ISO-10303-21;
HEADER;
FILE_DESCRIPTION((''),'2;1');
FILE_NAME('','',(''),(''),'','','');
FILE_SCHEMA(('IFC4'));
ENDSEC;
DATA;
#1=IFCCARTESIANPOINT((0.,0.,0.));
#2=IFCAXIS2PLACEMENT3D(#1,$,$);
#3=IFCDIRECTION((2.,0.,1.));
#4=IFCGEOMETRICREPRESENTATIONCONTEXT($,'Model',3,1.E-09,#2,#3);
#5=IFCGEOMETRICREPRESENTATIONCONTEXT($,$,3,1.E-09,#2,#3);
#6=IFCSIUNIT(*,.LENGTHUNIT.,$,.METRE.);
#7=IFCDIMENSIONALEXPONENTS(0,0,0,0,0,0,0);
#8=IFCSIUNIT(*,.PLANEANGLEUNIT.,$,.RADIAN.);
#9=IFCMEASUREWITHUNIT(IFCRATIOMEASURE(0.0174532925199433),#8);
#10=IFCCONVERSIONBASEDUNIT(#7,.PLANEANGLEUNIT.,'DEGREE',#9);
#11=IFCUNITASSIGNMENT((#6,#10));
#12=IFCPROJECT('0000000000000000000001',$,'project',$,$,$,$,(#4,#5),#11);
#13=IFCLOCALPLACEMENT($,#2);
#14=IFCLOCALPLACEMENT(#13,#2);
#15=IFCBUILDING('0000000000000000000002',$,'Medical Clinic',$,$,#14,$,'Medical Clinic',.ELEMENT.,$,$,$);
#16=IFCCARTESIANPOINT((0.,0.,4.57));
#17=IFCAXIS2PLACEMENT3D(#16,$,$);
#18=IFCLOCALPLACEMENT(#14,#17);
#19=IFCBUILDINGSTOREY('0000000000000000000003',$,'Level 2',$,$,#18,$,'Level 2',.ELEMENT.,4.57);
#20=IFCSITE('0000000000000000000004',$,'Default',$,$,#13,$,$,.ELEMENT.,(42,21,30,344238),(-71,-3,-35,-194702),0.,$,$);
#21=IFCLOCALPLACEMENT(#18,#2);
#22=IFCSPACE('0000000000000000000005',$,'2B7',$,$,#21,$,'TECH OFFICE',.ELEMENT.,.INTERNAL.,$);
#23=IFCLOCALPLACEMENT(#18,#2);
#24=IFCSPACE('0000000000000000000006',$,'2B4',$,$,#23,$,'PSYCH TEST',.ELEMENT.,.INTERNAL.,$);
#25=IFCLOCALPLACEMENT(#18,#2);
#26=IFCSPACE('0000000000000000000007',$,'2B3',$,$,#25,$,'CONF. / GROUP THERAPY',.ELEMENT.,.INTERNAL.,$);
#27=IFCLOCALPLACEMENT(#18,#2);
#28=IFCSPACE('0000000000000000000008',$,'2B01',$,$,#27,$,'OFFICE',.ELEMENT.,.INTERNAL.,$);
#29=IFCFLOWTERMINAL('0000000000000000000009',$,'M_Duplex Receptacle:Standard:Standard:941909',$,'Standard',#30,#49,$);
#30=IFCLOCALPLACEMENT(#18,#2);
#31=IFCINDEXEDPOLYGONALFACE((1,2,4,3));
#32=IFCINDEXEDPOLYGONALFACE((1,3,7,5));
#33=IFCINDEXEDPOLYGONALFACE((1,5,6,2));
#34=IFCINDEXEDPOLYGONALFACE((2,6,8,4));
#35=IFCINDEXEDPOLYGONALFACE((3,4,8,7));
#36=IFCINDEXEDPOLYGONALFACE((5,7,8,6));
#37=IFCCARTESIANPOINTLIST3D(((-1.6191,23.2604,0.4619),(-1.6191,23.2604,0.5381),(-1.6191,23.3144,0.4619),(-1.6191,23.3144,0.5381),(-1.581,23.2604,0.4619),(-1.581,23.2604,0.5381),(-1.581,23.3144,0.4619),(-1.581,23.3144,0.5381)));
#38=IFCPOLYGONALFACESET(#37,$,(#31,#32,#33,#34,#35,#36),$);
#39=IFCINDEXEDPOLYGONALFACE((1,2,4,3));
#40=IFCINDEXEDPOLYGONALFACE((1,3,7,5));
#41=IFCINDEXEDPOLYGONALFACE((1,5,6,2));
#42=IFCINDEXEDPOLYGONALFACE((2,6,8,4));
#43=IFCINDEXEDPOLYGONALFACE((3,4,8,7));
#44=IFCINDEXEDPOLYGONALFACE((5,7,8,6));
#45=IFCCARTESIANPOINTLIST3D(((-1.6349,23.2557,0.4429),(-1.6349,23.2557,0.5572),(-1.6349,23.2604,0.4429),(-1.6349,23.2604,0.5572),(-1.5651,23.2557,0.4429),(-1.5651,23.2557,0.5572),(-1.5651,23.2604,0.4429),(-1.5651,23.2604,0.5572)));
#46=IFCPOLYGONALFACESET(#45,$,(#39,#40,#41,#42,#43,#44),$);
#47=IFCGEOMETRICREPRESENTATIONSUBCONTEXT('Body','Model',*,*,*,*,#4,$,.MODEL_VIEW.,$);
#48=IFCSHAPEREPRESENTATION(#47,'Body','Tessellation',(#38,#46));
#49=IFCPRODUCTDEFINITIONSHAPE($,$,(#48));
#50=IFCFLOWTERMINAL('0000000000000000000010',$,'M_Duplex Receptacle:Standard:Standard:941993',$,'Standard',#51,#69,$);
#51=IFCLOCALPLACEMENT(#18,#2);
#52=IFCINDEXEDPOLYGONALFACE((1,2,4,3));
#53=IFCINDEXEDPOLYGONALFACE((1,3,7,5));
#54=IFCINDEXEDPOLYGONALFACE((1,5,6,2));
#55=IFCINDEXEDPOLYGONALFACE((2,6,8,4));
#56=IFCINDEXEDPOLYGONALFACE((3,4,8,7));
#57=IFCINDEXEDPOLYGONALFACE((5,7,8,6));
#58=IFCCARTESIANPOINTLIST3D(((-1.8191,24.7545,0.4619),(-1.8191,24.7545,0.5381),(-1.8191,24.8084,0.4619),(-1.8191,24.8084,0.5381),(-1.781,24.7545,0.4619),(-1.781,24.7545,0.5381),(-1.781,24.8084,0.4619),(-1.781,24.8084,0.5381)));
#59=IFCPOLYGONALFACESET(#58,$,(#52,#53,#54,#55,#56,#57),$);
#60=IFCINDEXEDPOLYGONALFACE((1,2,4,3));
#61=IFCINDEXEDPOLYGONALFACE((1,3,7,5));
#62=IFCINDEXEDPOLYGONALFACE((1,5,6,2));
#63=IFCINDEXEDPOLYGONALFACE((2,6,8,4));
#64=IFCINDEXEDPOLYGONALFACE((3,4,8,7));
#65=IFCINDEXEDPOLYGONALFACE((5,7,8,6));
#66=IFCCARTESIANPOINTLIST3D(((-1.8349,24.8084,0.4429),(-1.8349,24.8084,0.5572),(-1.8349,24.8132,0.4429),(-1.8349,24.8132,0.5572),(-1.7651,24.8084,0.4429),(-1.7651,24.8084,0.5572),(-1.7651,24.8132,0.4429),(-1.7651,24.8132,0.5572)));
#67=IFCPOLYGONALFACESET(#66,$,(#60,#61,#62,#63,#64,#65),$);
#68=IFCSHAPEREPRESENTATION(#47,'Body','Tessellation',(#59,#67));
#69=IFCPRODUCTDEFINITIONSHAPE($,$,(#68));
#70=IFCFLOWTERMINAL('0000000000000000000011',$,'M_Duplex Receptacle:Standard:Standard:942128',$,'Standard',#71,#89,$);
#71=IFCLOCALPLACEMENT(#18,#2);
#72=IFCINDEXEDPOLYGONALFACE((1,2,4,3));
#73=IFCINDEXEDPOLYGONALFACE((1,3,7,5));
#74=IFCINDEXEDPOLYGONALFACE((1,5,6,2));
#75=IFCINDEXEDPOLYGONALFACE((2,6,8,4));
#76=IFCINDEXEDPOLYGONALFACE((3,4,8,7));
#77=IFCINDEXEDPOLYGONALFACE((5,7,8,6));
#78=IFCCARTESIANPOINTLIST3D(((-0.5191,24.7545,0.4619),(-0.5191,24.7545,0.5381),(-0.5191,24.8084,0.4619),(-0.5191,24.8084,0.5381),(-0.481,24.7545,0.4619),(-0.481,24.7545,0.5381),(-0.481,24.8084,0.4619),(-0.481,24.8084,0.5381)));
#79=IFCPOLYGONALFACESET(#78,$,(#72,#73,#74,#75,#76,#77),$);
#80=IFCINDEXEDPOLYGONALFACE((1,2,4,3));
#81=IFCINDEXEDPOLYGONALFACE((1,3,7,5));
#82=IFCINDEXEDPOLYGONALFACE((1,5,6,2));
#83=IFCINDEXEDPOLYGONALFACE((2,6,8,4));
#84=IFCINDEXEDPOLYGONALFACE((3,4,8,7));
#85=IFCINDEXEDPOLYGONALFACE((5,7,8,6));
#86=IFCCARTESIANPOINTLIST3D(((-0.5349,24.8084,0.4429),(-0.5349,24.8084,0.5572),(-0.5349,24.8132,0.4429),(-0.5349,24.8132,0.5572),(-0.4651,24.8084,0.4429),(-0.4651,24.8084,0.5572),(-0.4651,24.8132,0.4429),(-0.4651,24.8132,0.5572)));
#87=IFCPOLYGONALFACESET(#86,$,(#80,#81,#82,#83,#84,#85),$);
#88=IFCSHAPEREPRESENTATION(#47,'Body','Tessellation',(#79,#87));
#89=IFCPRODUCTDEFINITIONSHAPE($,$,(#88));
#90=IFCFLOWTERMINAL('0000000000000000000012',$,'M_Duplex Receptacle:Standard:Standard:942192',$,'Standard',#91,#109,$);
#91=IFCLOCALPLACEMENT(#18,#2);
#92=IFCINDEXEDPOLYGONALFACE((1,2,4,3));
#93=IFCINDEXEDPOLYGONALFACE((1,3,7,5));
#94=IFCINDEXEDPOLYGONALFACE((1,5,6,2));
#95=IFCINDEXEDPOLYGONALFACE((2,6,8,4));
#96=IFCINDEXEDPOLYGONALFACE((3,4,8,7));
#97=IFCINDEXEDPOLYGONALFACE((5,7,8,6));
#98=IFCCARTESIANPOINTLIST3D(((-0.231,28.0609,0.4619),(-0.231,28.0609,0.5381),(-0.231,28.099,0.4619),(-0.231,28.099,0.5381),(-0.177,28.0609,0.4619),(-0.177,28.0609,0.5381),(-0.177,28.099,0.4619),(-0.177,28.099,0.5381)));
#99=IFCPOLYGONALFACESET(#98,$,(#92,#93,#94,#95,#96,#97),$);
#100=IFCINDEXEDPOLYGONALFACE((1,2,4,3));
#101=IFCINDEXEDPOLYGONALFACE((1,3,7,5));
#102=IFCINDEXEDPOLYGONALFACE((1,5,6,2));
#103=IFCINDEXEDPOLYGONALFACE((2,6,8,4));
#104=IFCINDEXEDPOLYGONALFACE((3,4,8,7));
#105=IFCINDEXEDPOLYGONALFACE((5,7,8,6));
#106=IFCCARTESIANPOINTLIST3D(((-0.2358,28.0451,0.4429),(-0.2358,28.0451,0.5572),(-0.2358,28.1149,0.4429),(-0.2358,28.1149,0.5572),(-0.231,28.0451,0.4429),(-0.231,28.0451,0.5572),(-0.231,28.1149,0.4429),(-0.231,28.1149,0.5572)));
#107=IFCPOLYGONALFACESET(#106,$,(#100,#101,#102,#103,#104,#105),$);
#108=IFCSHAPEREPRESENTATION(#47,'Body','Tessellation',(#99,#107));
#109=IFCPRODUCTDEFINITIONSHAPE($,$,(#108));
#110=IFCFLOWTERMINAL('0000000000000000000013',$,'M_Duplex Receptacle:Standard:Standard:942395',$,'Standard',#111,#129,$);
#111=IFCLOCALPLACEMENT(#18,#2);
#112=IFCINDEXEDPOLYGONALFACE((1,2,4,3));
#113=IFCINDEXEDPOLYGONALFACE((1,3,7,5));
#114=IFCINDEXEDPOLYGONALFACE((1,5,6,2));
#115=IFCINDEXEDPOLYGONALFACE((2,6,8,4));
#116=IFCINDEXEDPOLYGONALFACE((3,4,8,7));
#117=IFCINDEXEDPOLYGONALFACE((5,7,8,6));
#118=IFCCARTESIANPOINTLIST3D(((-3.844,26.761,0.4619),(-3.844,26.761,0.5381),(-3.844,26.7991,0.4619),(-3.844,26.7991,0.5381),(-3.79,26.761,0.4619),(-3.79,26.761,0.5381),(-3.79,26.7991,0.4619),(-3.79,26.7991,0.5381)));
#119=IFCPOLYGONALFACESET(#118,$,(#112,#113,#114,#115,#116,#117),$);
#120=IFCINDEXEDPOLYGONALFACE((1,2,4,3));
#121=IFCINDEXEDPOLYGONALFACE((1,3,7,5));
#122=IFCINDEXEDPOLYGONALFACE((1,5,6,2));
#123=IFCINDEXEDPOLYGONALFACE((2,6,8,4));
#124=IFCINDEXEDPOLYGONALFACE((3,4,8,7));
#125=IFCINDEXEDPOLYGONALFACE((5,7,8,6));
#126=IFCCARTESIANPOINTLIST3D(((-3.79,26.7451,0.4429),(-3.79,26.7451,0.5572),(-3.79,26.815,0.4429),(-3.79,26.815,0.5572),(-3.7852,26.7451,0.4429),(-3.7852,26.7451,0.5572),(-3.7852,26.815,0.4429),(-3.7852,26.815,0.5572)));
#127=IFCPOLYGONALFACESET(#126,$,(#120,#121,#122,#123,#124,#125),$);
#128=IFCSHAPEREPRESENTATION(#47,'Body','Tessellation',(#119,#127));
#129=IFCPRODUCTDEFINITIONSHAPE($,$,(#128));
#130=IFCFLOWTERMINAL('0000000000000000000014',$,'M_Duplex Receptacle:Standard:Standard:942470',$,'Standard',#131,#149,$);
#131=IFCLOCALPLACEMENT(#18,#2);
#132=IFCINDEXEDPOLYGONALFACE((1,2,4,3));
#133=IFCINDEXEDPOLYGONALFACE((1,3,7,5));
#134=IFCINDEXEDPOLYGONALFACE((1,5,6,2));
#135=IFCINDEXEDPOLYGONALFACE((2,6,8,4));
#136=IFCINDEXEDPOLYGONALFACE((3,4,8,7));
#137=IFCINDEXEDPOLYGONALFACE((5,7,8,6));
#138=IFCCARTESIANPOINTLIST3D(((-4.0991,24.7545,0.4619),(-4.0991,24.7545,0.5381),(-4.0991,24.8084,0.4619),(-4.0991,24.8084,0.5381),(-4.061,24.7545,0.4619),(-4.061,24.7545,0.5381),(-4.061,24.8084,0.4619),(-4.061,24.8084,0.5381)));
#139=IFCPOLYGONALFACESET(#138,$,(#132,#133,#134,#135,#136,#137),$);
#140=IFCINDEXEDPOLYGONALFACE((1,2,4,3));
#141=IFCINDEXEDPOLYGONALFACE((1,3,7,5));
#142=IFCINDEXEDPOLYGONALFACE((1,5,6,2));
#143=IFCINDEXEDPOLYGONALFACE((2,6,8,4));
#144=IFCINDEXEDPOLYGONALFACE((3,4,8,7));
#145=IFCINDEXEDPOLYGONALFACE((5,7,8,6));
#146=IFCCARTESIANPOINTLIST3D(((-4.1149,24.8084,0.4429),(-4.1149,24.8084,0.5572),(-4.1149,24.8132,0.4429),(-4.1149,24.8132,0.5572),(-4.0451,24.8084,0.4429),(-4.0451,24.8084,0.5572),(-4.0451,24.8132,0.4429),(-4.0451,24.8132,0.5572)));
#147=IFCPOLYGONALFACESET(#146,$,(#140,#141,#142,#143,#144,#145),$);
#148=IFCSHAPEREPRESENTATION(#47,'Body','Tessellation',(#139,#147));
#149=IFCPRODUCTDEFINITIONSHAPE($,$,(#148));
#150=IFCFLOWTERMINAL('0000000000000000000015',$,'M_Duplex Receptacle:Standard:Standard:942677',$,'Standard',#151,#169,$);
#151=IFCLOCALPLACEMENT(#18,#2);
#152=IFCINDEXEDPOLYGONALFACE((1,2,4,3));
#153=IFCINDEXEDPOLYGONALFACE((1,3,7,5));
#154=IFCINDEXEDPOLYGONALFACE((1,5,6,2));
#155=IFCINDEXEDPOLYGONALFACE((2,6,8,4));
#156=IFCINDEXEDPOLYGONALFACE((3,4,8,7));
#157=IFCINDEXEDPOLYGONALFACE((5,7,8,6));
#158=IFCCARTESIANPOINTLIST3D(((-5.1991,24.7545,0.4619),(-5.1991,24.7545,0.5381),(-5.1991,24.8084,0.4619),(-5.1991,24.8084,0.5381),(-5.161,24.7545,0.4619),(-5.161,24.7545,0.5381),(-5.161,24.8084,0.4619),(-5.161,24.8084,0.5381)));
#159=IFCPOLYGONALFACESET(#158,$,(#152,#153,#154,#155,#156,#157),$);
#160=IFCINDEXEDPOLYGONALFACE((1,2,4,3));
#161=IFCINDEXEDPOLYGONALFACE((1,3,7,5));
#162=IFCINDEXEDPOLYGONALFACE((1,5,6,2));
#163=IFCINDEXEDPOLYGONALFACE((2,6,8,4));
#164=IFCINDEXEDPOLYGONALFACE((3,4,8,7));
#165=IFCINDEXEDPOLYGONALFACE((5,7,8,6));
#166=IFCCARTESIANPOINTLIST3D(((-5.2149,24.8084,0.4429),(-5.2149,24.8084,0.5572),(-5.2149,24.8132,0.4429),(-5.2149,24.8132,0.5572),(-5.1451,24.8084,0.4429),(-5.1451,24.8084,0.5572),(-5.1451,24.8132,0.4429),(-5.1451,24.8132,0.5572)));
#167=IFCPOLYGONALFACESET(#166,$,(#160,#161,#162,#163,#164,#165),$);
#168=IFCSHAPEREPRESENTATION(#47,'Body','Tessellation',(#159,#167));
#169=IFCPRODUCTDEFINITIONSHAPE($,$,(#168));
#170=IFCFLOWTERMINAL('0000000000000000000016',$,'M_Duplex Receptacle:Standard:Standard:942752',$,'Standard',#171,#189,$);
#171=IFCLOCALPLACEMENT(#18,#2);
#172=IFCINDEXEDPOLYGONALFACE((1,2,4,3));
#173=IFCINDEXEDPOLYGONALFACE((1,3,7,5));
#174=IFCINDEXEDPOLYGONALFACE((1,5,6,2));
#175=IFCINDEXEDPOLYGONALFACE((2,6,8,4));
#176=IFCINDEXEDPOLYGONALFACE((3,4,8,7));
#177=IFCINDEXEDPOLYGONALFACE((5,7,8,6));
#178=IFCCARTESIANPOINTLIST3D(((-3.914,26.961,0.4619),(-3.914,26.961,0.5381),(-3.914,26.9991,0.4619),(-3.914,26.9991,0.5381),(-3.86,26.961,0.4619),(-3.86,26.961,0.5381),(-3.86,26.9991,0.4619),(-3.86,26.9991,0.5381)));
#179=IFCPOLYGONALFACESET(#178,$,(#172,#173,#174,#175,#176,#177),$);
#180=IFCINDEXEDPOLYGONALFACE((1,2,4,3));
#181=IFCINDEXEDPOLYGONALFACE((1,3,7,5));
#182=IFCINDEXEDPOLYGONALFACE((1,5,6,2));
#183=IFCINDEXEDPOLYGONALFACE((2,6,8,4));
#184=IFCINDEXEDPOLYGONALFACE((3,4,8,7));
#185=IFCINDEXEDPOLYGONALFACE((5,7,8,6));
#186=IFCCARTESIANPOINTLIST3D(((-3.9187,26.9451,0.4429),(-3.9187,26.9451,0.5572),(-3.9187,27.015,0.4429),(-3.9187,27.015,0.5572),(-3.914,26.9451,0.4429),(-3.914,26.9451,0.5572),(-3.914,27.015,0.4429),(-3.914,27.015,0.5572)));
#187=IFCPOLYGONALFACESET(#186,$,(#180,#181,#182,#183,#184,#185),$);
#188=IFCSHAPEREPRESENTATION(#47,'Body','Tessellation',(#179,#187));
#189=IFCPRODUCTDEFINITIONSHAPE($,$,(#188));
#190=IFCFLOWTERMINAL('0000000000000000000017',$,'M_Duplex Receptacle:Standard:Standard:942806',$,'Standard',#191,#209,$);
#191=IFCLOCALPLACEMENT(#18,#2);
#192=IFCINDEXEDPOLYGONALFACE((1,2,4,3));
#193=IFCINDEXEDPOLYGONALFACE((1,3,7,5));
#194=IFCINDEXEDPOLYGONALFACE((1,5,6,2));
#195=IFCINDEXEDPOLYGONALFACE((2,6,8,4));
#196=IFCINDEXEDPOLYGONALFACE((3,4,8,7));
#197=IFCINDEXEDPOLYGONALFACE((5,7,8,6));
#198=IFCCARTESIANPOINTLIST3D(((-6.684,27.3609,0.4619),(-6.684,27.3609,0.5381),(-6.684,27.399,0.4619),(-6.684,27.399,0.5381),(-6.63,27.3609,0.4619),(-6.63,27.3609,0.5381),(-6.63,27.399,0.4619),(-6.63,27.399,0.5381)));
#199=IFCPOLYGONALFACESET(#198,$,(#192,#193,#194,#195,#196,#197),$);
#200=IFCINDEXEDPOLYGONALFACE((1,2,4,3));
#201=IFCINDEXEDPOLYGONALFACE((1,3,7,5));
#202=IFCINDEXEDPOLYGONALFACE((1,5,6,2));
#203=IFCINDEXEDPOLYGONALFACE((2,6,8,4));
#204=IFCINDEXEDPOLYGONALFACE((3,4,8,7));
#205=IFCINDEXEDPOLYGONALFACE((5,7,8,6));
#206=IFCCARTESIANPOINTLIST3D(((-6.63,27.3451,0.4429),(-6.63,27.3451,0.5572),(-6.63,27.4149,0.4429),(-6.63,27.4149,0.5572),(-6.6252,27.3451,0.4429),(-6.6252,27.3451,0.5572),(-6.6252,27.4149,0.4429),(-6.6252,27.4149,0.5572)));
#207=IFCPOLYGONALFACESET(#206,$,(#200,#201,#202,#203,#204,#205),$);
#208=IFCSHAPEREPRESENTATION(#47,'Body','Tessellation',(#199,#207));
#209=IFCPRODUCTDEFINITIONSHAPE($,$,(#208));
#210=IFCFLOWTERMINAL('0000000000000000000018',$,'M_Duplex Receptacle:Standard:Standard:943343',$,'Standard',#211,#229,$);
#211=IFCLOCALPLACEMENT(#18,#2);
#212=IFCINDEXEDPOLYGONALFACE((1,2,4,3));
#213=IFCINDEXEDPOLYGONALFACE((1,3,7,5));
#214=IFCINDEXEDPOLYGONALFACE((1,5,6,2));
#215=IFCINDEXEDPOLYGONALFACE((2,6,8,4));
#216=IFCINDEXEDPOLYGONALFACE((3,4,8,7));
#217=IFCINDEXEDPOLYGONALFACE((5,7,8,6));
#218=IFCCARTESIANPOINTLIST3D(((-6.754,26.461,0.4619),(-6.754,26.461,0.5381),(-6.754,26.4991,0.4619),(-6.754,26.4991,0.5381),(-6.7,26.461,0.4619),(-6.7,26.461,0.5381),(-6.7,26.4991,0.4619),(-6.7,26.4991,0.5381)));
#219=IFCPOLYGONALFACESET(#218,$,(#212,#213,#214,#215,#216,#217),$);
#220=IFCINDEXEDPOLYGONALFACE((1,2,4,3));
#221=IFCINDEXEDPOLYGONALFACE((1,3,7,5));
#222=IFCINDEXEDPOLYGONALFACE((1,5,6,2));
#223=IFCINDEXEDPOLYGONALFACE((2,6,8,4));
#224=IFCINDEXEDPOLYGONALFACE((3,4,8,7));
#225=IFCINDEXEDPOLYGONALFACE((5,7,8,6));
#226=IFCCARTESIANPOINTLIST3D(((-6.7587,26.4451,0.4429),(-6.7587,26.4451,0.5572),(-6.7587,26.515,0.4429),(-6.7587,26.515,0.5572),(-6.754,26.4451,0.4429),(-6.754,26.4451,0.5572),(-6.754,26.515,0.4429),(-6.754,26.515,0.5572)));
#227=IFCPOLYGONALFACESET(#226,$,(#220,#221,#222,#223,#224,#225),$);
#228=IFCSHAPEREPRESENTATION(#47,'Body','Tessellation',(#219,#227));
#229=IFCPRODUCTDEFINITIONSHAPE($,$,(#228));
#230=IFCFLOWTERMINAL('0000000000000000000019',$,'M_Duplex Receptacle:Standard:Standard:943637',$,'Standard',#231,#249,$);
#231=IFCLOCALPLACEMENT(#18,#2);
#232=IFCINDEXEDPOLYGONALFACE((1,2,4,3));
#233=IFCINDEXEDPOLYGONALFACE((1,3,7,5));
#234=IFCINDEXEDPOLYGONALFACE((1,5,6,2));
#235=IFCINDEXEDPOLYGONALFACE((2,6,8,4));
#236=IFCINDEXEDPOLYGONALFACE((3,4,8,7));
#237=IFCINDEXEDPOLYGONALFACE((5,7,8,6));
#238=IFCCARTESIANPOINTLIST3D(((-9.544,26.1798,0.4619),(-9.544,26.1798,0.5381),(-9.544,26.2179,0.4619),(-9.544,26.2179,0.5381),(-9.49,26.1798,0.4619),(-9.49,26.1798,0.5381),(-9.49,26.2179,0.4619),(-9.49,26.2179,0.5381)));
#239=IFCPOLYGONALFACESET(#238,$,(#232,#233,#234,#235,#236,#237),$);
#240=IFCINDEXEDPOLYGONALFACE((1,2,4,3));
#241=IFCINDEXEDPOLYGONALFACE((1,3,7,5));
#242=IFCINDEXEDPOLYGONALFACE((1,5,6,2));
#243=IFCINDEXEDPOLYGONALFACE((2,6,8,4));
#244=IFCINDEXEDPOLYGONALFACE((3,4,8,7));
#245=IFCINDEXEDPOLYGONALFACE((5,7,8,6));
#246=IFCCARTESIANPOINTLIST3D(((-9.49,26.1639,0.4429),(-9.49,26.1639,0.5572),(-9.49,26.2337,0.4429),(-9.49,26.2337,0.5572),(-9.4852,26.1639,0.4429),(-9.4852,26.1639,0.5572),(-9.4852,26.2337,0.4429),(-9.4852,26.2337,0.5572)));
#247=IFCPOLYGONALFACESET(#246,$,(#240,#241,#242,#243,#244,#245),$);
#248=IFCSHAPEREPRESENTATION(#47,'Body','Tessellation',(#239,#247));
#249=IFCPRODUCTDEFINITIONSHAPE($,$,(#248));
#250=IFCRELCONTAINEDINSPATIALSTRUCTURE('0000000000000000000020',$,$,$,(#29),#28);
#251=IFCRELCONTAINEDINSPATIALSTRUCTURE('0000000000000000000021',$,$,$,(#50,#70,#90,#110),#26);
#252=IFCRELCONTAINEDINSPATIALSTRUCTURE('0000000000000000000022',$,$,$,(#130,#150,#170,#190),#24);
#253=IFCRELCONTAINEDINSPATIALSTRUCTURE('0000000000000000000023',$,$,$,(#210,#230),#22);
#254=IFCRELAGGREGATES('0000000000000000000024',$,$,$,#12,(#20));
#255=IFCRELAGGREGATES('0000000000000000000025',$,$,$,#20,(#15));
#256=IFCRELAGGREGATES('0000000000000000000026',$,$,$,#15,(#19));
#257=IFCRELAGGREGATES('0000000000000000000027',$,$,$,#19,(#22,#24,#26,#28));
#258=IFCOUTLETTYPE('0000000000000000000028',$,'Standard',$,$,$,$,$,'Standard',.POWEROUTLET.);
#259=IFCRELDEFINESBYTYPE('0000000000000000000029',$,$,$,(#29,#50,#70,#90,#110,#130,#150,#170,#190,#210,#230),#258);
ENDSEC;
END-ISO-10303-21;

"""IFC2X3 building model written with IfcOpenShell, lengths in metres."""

from ifc_helpers import new_model, entity, si_unit, converted_unit, direction, frame, frame_2d, origin, origin_2d_with_axis, place, context, subcontext, project, spatial, rectangle, extrude, source, transform, mapped, type_object, type_shapes, element, save


model = new_model("IFC2X3")

# Units and contexts
model_context = context("Model", 3, precision=1e-09, world=origin(), true_north=direction((2.0, 0.0, 1.0)))
context_of_model = context(None, 3, precision=1e-09, world=origin(), true_north=direction((2.0, 0.0, 1.0)))
body_context = subcontext(model_context, "Body", "Model", "MODEL_VIEW")
ifc_project = project(units=[si_unit("LENGTHUNIT", "METRE"), converted_unit("PLANEANGLEUNIT", "DEGREE", entity("IfcRatioMeasure", 0.0174532925199433), si_unit("PLANEANGLEUNIT", "RADIAN"), dimensions=[0, 0, 0, 0, 0, 0, 0])], contexts=[model_context, context_of_model])

# Site, building, storey
site_placement = place(None, origin())
site = spatial("IfcSite", under=ifc_project, at=site_placement, Name="Default", CompositionType="ELEMENT", RefLatitude=(42, 21, 30, 344238), RefLongitude=(-71, -3, -35, -194702), RefElevation=0.0)
building_placement = place(site_placement, origin())
building = spatial("IfcBuilding", under=site, at=building_placement, Name="Medical Clinic", LongName="Medical Clinic", CompositionType="ELEMENT")
storey_placement = place(building_placement, frame((0.0, 0.0, 4.57)))
storey = spatial("IfcBuildingStorey", under=building, at=storey_placement, Name="Level 2", LongName="Level 2", CompositionType="ELEMENT", Elevation=4.57)

# Shared definitions
space_1_placement = place(storey_placement, origin())
space_1 = spatial("IfcSpace", under=storey, at=space_1_placement, Name="2B7", LongName="TECH OFFICE", CompositionType="ELEMENT", InteriorOrExteriorSpace="INTERNAL")

# Shared definitions
space_2_placement = place(storey_placement, origin())
space_2 = spatial("IfcSpace", under=storey, at=space_2_placement, Name="2B4", LongName="PSYCH TEST", CompositionType="ELEMENT", InteriorOrExteriorSpace="INTERNAL")

# Shared definitions
space_3_placement = place(storey_placement, origin())
space_3 = spatial("IfcSpace", under=storey, at=space_3_placement, Name="2B3", LongName="CONF. / GROUP THERAPY", CompositionType="ELEMENT", InteriorOrExteriorSpace="INTERNAL")

# Shared definitions
space_4_placement = place(storey_placement, origin())
space_4 = spatial("IfcSpace", under=storey, at=space_4_placement, Name="2B01", LongName="OFFICE", CompositionType="ELEMENT", InteriorOrExteriorSpace="INTERNAL")

# Flow terminals
outlet_type = type_object("IfcOutletType", Name="Standard", ElementType="Standard", PredefinedType="POWEROUTLET")
shared_shape_1 = source(origin(), body_context, "Body", "SweptSolid", [
    extrude(rectangle(XDim=0.0381, YDim=0.0762, at=origin_2d_with_axis()), frame((0.0, 0.0, -0.054), z_axis=(0.0, 0.0, 1.0), x_axis=(-1.0, 0.0, 0.0)), (0.0, 0.0, 1.0), 0.054),
    extrude(rectangle(XDim=0.0698, YDim=0.1143, at=frame_2d((0.0, 0.0), x_axis=(1.0, 0.0))), frame((0.0, 0.0, 0.0), z_axis=(0.0, 0.0, 1.0), x_axis=(-1.0, 0.0, 0.0)), (0.0, 0.0, 1.0), 0.0048),
])
type_shapes(outlet_type, [shared_shape_1])
flow_terminal_1_placement = place(space_4_placement, frame((-1.6, 23.2604, 0.5), z_axis=(0.0, -1.0, 0.0), x_axis=(1.0, 0.0, 0.0)))
element("IfcFlowTerminal", 1, at=flow_terminal_1_placement, inside=space_4, type_object=outlet_type, Name="M_Duplex Receptacle:Standard:Standard:941909", ObjectType="Standard", context=body_context, shape_type="MappedRepresentation", body=[
    mapped(shared_shape_1, transform((0.0, 0.0, 0.0), scale=1.0)),
])
for number, where, z_axis, x_axis, name in (
    (2, (-1.8, 24.8084, 0.5), (0.0, 1.0, 0.0), (-1.0, 0.0, 0.0), "M_Duplex Receptacle:Standard:Standard:941993"),
    (3, (-0.5, 24.8084, 0.5), (0.0, 1.0, 0.0), (-1.0, 0.0, 0.0), "M_Duplex Receptacle:Standard:Standard:942128"),
    (4, (-0.231, 28.08, 0.5), (-1.0, 0.0, 0.0), (0.0, -1.0, 0.0), "M_Duplex Receptacle:Standard:Standard:942192"),
    (5, (-3.79, 26.7801, 0.5), (1.0, 0.0, 0.0), (0.0, 1.0, 0.0), "M_Duplex Receptacle:Standard:Standard:942395"),
):
    element("IfcFlowTerminal", number, at=place(space_3_placement, frame(where, z_axis=z_axis, x_axis=x_axis)), inside=space_3, type_object=outlet_type, Name=name, ObjectType="Standard", context=body_context, shape_type="MappedRepresentation", body=[
        mapped(shared_shape_1, transform((0.0, 0.0, 0.0), scale=1.0)),
    ])
for number, where, z_axis, x_axis, name in (
    (6, (-4.08, 24.8084, 0.5), (0.0, 1.0, 0.0), (-1.0, 0.0, 0.0), "M_Duplex Receptacle:Standard:Standard:942470"),
    (7, (-5.18, 24.8084, 0.5), (0.0, 1.0, 0.0), (-1.0, 0.0, 0.0), "M_Duplex Receptacle:Standard:Standard:942677"),
    (8, (-3.914, 26.9801, 0.5), (-1.0, 0.0, 0.0), (0.0, -1.0, 0.0), "M_Duplex Receptacle:Standard:Standard:942752"),
    (9, (-6.63, 27.38, 0.5), (1.0, 0.0, 0.0), (0.0, 1.0, 0.0), "M_Duplex Receptacle:Standard:Standard:942806"),
):
    element("IfcFlowTerminal", number, at=place(space_2_placement, frame(where, z_axis=z_axis, x_axis=x_axis)), inside=space_2, type_object=outlet_type, Name=name, ObjectType="Standard", context=body_context, shape_type="MappedRepresentation", body=[
        mapped(shared_shape_1, transform((0.0, 0.0, 0.0), scale=1.0)),
    ])
for number, where, z_axis, x_axis, name in (
    (10, (-6.754, 26.4801, 0.5), (-1.0, 0.0, 0.0), (0.0, -1.0, 0.0), "M_Duplex Receptacle:Standard:Standard:943343"),
    (11, (-9.49, 26.1988, 0.5), (1.0, 0.0, 0.0), (0.0, 1.0, 0.0), "M_Duplex Receptacle:Standard:Standard:943637"),
):
    element("IfcFlowTerminal", number, at=place(space_1_placement, frame(where, z_axis=z_axis, x_axis=x_axis)), inside=space_1, type_object=outlet_type, Name=name, ObjectType="Standard", context=body_context, shape_type="MappedRepresentation", body=[
        mapped(shared_shape_1, transform((0.0, 0.0, 0.0), scale=1.0)),
    ])

save(model, "model.ifc")
